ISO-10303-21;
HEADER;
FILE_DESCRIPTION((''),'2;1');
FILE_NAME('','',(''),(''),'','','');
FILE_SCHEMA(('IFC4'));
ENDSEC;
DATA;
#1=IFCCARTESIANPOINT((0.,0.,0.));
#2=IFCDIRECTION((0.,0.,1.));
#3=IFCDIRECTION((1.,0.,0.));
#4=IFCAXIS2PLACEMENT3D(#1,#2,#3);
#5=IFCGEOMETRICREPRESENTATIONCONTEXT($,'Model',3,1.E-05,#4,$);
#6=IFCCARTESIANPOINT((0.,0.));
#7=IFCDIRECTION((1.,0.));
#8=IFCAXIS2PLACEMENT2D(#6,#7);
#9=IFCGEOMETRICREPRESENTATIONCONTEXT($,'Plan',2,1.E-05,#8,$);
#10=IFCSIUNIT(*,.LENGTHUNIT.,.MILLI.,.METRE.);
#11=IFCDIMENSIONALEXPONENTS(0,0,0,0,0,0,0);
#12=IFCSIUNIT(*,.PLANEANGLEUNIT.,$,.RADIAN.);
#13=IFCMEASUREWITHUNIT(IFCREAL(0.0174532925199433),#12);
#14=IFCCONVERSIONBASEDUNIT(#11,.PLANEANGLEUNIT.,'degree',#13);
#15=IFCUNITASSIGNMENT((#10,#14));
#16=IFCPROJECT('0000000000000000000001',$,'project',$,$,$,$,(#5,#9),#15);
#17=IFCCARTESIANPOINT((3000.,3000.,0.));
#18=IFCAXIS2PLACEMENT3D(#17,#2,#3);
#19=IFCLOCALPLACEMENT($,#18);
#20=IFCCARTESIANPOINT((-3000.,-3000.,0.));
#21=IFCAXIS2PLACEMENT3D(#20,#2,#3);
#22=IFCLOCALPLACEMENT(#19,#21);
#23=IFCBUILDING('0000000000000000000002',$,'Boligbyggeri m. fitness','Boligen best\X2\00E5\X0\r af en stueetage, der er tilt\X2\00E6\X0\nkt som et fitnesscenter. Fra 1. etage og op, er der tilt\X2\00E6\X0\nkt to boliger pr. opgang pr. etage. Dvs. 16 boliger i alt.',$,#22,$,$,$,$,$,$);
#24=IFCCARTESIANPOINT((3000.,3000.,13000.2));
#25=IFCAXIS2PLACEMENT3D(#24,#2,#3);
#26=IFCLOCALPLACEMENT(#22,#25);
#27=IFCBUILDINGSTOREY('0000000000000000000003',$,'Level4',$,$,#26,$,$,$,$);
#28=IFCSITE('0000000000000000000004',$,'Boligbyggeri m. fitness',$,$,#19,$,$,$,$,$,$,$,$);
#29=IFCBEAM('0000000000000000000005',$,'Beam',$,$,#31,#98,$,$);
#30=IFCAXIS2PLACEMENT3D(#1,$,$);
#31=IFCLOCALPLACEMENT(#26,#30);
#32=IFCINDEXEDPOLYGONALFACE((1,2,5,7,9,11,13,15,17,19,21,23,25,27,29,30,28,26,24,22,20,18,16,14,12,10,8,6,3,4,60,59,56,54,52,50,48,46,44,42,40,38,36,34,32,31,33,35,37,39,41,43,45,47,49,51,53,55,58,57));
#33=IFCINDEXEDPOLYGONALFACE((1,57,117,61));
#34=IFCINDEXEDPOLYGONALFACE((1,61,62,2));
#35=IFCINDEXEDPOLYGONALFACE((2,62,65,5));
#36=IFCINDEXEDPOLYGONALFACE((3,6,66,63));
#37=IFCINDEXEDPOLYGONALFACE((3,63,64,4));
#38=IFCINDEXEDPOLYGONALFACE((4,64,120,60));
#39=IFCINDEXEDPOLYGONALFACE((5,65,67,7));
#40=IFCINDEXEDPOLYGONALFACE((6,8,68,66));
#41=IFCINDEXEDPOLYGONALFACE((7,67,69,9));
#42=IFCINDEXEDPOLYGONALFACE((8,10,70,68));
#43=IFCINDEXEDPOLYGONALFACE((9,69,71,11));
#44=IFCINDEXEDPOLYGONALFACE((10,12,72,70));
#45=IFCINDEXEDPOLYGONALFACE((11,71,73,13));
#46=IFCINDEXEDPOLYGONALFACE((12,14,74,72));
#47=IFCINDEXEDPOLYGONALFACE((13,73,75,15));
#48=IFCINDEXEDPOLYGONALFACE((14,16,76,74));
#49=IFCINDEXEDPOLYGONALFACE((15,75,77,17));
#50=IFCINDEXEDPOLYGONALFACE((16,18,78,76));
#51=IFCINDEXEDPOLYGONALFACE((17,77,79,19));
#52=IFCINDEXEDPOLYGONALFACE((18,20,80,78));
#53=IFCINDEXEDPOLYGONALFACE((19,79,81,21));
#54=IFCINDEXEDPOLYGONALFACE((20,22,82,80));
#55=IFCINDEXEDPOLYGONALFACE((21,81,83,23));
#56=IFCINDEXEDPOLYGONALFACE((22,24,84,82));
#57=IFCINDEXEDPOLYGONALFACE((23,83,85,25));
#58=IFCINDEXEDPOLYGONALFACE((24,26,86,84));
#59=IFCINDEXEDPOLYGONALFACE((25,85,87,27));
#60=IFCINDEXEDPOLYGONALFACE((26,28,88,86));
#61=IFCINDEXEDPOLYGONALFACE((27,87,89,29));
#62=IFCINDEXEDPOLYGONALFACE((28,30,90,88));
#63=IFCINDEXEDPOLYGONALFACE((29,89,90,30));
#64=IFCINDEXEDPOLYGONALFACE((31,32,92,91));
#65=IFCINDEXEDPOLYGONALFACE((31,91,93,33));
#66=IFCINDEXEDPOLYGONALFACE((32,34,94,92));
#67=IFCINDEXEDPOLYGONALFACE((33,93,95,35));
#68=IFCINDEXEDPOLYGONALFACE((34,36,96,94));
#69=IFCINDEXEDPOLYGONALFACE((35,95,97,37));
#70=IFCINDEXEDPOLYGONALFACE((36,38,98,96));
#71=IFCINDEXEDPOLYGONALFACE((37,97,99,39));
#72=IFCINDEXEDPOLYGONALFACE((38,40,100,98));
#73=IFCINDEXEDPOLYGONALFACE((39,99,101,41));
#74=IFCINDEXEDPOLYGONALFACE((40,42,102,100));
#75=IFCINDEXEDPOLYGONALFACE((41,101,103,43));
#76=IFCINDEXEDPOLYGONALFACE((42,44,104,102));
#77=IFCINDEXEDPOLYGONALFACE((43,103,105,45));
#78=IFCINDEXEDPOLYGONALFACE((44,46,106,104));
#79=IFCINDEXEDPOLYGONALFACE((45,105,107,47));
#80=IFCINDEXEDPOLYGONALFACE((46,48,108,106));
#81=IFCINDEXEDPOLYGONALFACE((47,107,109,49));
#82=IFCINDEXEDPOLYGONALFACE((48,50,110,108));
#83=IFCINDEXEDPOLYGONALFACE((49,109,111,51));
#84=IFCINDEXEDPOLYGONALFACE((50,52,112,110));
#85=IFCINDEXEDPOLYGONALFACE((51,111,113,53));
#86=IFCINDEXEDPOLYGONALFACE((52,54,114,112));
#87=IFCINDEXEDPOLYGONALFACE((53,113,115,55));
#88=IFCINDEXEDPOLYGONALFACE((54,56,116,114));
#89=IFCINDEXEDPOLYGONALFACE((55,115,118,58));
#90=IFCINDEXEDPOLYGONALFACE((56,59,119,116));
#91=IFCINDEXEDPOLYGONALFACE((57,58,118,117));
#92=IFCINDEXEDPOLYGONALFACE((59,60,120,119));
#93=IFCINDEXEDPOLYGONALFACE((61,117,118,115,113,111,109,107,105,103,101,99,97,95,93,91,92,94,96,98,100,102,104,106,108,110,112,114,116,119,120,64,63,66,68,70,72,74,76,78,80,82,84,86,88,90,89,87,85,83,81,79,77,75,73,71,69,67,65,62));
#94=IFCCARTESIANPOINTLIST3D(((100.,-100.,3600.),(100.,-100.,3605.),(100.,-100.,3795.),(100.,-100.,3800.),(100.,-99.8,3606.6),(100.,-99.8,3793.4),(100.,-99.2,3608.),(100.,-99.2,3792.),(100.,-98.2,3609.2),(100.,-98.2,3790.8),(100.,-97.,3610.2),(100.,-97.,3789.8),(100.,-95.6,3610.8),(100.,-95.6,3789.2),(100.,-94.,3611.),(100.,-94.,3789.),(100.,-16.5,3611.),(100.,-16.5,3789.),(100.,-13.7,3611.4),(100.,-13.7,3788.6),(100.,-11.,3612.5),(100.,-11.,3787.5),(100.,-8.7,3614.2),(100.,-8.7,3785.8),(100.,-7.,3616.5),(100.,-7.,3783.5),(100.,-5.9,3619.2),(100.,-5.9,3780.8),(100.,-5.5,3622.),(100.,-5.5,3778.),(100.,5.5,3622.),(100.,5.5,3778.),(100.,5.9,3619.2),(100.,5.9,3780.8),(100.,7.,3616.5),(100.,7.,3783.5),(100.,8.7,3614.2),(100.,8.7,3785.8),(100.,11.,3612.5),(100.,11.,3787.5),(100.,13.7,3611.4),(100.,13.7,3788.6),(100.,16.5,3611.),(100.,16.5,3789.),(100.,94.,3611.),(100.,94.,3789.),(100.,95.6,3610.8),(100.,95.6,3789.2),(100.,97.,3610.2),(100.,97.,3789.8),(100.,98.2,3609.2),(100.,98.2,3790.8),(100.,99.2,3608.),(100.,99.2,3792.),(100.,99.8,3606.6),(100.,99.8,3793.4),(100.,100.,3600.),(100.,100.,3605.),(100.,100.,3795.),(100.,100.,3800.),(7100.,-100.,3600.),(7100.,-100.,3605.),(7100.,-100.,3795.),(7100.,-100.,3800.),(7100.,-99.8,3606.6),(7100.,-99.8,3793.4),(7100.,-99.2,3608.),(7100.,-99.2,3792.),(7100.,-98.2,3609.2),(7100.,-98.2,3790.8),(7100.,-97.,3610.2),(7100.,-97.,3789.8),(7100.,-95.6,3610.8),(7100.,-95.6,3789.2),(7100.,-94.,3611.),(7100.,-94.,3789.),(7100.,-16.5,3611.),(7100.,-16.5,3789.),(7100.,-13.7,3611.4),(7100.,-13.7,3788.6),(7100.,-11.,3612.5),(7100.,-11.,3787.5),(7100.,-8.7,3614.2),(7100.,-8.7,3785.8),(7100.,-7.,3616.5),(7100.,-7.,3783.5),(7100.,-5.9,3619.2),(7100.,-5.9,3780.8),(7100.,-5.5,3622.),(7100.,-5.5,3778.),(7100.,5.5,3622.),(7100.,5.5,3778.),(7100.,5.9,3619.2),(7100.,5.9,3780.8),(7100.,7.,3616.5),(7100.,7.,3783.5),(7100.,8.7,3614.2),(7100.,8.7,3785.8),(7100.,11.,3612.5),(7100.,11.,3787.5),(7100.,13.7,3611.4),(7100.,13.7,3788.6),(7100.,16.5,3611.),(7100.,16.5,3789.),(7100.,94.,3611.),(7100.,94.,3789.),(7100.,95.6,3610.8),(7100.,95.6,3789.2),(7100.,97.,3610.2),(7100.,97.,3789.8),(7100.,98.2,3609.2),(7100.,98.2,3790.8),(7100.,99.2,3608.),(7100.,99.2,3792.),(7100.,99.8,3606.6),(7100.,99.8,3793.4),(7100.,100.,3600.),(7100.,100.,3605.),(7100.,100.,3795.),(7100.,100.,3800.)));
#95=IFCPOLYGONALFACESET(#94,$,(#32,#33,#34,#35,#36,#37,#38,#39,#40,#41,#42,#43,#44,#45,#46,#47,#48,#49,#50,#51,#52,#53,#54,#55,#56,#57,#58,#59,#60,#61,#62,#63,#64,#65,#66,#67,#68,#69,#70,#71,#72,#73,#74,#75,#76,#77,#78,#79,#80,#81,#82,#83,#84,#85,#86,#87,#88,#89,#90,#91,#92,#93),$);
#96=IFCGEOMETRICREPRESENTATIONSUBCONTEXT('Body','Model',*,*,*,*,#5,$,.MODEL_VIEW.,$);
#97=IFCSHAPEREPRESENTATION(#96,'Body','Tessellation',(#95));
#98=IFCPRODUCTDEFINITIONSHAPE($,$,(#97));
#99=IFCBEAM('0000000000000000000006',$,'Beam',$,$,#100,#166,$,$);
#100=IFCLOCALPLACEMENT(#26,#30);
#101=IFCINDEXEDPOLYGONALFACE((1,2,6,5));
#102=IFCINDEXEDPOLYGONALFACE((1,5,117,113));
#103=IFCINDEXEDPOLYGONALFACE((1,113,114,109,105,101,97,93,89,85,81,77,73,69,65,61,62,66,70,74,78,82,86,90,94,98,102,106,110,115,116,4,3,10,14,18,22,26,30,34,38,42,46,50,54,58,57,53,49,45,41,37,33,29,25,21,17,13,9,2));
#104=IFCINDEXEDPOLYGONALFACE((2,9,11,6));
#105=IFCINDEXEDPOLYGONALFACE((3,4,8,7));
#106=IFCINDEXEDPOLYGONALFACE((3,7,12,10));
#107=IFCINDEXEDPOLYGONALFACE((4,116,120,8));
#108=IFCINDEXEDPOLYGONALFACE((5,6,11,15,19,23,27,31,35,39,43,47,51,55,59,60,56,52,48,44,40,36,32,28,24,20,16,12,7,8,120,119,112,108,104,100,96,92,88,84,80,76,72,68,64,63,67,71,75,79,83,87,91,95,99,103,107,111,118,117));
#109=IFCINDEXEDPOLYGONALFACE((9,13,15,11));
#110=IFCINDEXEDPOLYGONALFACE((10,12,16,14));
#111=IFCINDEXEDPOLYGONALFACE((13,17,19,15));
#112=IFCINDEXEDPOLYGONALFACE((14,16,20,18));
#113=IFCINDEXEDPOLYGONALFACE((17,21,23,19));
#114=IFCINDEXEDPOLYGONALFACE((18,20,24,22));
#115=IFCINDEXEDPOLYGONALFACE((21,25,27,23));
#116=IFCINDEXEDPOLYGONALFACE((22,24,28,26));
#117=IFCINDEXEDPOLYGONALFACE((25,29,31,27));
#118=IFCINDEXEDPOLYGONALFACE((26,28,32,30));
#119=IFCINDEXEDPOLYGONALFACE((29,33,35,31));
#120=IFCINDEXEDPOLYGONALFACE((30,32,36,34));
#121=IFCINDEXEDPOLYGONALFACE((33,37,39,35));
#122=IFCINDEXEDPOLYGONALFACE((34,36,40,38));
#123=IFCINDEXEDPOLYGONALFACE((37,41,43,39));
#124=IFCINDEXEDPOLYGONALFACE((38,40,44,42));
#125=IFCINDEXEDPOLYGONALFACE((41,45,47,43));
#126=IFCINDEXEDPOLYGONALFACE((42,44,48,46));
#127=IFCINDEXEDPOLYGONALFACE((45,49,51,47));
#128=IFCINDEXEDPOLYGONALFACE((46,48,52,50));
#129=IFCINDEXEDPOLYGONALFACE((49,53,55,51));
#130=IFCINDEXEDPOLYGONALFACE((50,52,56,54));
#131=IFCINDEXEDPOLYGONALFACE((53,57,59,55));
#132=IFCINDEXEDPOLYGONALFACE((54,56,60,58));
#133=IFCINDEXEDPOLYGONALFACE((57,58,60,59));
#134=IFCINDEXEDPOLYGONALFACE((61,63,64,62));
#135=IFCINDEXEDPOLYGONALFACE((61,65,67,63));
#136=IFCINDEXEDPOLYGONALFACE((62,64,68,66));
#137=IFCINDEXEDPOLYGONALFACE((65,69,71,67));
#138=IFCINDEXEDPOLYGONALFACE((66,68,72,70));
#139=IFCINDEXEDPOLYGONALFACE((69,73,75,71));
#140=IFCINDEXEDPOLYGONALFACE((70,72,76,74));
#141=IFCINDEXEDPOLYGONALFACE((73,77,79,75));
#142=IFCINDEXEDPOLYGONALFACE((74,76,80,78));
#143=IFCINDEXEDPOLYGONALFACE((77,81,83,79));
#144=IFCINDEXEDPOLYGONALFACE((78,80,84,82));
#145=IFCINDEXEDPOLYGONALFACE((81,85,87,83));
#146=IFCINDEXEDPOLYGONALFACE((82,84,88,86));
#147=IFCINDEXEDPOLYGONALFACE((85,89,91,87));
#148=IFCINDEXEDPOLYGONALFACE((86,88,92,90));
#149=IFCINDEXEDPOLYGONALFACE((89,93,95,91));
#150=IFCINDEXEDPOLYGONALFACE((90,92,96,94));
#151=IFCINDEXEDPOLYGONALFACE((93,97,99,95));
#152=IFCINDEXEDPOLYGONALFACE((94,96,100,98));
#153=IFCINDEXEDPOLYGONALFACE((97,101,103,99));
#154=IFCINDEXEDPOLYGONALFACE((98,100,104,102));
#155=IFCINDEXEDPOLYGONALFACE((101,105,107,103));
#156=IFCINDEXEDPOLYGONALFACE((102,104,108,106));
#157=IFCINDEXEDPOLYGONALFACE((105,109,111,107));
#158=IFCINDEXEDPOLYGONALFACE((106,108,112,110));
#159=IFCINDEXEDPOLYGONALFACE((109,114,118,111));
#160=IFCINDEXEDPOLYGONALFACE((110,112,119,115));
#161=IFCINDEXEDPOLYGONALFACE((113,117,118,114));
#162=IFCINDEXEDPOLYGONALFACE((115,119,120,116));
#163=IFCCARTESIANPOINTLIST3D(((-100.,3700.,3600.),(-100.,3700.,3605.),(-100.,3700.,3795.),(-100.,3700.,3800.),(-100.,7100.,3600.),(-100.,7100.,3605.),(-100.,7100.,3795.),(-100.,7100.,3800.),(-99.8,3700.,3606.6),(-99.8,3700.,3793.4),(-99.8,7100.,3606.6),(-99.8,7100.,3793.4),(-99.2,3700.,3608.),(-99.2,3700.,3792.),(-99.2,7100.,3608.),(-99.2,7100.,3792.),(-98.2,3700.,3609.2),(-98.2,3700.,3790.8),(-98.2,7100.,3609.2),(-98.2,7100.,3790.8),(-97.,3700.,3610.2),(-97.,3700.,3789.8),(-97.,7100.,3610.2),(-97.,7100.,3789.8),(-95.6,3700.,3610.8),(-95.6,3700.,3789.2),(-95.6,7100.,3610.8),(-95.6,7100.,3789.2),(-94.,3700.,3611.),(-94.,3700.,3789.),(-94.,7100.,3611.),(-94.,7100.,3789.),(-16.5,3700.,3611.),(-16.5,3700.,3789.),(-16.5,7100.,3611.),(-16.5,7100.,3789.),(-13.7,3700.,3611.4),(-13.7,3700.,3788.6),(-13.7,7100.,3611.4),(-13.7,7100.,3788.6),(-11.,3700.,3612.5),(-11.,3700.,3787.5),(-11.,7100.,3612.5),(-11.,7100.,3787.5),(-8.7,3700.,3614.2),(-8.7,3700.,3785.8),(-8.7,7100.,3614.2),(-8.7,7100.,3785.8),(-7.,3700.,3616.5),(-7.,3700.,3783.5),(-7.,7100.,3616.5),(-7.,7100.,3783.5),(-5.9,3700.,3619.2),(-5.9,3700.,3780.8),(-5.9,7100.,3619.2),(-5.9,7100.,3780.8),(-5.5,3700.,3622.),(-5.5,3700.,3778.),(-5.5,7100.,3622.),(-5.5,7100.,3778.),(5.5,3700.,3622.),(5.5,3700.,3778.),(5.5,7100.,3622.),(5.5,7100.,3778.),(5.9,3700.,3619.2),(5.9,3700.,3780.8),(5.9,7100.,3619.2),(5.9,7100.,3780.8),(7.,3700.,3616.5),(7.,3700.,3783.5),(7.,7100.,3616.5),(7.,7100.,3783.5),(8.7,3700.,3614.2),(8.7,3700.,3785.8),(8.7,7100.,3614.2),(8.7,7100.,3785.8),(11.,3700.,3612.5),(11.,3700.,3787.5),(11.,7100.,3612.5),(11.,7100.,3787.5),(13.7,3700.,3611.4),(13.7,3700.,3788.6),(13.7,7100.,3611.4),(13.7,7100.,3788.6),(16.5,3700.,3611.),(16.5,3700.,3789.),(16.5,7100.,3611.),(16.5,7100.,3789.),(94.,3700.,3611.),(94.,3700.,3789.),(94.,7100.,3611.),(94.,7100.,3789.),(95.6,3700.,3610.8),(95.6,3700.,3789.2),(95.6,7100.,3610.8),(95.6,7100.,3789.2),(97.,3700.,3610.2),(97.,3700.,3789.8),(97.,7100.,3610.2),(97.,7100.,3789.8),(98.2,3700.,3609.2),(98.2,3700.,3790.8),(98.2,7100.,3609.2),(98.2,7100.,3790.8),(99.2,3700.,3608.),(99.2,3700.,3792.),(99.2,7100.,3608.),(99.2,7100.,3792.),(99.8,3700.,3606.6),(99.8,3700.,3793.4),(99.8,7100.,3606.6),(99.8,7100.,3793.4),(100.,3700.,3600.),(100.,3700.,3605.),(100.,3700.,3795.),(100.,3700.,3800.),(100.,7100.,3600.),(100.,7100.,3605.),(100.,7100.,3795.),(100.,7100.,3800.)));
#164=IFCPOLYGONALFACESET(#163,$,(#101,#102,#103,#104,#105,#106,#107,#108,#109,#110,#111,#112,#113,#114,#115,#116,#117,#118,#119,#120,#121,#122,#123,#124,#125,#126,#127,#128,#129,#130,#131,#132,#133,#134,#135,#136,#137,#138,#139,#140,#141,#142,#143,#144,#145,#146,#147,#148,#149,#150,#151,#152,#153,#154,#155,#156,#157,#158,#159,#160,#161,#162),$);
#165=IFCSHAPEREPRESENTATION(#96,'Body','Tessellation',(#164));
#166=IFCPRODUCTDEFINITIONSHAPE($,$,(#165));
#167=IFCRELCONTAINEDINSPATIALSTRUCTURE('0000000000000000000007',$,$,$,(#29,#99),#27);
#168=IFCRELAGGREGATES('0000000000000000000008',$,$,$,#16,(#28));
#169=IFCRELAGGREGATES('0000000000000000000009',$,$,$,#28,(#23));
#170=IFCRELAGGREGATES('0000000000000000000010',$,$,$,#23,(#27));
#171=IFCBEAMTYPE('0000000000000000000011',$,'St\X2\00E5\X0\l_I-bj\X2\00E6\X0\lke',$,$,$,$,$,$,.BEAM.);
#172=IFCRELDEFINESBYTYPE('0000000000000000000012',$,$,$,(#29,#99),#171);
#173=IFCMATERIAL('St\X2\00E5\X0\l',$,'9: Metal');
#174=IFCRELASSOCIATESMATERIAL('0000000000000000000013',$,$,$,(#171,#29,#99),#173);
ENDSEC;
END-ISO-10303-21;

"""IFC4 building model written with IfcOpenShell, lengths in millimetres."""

from ifc_helpers import new_model, entity, si_unit, converted_unit, frame, origin_with_axes, origin_2d_with_axis, place, context, subcontext, project, spatial, i_section, extrude, material, material_profile, profile_set, profile_usage, type_object, element, save


model = new_model("IFC4")

# Units and contexts
model_context = context("Model", 3, precision=1e-05, world=origin_with_axes())
plan_context = context("Plan", 2, precision=1e-05, world=origin_2d_with_axis())
body_context = subcontext(model_context, "Body", "Model", "MODEL_VIEW")
ifc_project = project(units=[si_unit("LENGTHUNIT", "METRE", prefix="MILLI"), converted_unit("PLANEANGLEUNIT", "degree", entity("IfcReal", 0.0174532925199433), si_unit("PLANEANGLEUNIT", "RADIAN"), dimensions=[0, 0, 0, 0, 0, 0, 0])], contexts=[model_context, plan_context])

# Site, building, storey
site_placement = place(None, frame((3000.0, 3000.0, 0.0), z_axis=(0.0, 0.0, 1.0), x_axis=(1.0, 0.0, 0.0)))
site = spatial("IfcSite", under=ifc_project, at=site_placement, Name="Boligbyggeri m. fitness")
building_placement = place(site_placement, frame((-3000.0, -3000.0, 0.0), z_axis=(0.0, 0.0, 1.0), x_axis=(1.0, 0.0, 0.0)))
building = spatial("IfcBuilding", under=site, at=building_placement, Name="Boligbyggeri m. fitness", Description="Boligen består af en stueetage, der er tiltænkt som et fitnesscenter. Fra 1. etage og op, er der tiltænkt to boliger pr. opgang pr. etage. Dvs. 16 boliger i alt.")
storey_placement = place(building_placement, frame((3000.0, 3000.0, 13000.2), z_axis=(0.0, 0.0, 1.0), x_axis=(1.0, 0.0, 0.0)))
storey = spatial("IfcBuildingStorey", under=building, at=storey_placement, Name="Level4")

# Beams
ifc_material_1 = material(Name="Stål", Category="9: Metal")
ifc_material_profile_1 = material_profile(ifc_material_1, i_section(OverallWidth=200.0, OverallDepth=200.0, WebThickness=11.0, FlangeThickness=11.0, FilletRadius=11.0, FlangeEdgeRadius=6.0), Name="Stål", Category="9: Metal")
ifc_profile_set_1 = profile_set([ifc_material_profile_1], Name="NY_I-Profil")
beam_type = type_object("IfcBeamType", Name="Stål_I-bjælke", PredefinedType="BEAM", material=ifc_profile_set_1)
ifc_profile_usage_1 = profile_usage(ifc_profile_set_1, cardinal=7)
beam_1_placement = place(storey_placement, frame((100.0, 100.0, 3800.0), z_axis=(1.0, 0.0, 0.0), x_axis=(0.0, 1.0, 0.0)))
element("IfcBeam", 1, at=beam_1_placement, inside=storey, type_object=beam_type, material=ifc_profile_usage_1, Name="Beam", context=body_context, shape_type="SweptSolid", body=[
    extrude(i_section(OverallWidth=200.0, OverallDepth=200.0, WebThickness=11.0, FlangeThickness=11.0, FilletRadius=11.0, FlangeEdgeRadius=6.0), frame((-100.0, -100.0, 0.0), z_axis=(0.0, 0.0, 1.0), x_axis=(1.0, 0.0, 0.0)), (0.0, 0.0, 1.0), 7000.0),
])
ifc_profile_usage_2 = profile_usage(ifc_profile_set_1, cardinal=9)
beam_2_placement = place(storey_placement, frame((100.0, 3700.0, 3800.0), z_axis=(0.0, 1.0, 0.0), x_axis=(-1.0, 0.0, 0.0)))
element("IfcBeam", 2, at=beam_2_placement, inside=storey, type_object=beam_type, material=ifc_profile_usage_2, Name="Beam", context=body_context, shape_type="SweptSolid", body=[
    extrude(i_section(OverallWidth=200.0, OverallDepth=200.0, WebThickness=11.0, FlangeThickness=11.0, FilletRadius=11.0, FlangeEdgeRadius=6.0), frame((100.0, -100.0, 0.0), z_axis=(0.0, 0.0, 1.0), x_axis=(1.0, 0.0, 0.0)), (0.0, 0.0, 1.0), 3400.0),
])

save(model, "model.ifc")
